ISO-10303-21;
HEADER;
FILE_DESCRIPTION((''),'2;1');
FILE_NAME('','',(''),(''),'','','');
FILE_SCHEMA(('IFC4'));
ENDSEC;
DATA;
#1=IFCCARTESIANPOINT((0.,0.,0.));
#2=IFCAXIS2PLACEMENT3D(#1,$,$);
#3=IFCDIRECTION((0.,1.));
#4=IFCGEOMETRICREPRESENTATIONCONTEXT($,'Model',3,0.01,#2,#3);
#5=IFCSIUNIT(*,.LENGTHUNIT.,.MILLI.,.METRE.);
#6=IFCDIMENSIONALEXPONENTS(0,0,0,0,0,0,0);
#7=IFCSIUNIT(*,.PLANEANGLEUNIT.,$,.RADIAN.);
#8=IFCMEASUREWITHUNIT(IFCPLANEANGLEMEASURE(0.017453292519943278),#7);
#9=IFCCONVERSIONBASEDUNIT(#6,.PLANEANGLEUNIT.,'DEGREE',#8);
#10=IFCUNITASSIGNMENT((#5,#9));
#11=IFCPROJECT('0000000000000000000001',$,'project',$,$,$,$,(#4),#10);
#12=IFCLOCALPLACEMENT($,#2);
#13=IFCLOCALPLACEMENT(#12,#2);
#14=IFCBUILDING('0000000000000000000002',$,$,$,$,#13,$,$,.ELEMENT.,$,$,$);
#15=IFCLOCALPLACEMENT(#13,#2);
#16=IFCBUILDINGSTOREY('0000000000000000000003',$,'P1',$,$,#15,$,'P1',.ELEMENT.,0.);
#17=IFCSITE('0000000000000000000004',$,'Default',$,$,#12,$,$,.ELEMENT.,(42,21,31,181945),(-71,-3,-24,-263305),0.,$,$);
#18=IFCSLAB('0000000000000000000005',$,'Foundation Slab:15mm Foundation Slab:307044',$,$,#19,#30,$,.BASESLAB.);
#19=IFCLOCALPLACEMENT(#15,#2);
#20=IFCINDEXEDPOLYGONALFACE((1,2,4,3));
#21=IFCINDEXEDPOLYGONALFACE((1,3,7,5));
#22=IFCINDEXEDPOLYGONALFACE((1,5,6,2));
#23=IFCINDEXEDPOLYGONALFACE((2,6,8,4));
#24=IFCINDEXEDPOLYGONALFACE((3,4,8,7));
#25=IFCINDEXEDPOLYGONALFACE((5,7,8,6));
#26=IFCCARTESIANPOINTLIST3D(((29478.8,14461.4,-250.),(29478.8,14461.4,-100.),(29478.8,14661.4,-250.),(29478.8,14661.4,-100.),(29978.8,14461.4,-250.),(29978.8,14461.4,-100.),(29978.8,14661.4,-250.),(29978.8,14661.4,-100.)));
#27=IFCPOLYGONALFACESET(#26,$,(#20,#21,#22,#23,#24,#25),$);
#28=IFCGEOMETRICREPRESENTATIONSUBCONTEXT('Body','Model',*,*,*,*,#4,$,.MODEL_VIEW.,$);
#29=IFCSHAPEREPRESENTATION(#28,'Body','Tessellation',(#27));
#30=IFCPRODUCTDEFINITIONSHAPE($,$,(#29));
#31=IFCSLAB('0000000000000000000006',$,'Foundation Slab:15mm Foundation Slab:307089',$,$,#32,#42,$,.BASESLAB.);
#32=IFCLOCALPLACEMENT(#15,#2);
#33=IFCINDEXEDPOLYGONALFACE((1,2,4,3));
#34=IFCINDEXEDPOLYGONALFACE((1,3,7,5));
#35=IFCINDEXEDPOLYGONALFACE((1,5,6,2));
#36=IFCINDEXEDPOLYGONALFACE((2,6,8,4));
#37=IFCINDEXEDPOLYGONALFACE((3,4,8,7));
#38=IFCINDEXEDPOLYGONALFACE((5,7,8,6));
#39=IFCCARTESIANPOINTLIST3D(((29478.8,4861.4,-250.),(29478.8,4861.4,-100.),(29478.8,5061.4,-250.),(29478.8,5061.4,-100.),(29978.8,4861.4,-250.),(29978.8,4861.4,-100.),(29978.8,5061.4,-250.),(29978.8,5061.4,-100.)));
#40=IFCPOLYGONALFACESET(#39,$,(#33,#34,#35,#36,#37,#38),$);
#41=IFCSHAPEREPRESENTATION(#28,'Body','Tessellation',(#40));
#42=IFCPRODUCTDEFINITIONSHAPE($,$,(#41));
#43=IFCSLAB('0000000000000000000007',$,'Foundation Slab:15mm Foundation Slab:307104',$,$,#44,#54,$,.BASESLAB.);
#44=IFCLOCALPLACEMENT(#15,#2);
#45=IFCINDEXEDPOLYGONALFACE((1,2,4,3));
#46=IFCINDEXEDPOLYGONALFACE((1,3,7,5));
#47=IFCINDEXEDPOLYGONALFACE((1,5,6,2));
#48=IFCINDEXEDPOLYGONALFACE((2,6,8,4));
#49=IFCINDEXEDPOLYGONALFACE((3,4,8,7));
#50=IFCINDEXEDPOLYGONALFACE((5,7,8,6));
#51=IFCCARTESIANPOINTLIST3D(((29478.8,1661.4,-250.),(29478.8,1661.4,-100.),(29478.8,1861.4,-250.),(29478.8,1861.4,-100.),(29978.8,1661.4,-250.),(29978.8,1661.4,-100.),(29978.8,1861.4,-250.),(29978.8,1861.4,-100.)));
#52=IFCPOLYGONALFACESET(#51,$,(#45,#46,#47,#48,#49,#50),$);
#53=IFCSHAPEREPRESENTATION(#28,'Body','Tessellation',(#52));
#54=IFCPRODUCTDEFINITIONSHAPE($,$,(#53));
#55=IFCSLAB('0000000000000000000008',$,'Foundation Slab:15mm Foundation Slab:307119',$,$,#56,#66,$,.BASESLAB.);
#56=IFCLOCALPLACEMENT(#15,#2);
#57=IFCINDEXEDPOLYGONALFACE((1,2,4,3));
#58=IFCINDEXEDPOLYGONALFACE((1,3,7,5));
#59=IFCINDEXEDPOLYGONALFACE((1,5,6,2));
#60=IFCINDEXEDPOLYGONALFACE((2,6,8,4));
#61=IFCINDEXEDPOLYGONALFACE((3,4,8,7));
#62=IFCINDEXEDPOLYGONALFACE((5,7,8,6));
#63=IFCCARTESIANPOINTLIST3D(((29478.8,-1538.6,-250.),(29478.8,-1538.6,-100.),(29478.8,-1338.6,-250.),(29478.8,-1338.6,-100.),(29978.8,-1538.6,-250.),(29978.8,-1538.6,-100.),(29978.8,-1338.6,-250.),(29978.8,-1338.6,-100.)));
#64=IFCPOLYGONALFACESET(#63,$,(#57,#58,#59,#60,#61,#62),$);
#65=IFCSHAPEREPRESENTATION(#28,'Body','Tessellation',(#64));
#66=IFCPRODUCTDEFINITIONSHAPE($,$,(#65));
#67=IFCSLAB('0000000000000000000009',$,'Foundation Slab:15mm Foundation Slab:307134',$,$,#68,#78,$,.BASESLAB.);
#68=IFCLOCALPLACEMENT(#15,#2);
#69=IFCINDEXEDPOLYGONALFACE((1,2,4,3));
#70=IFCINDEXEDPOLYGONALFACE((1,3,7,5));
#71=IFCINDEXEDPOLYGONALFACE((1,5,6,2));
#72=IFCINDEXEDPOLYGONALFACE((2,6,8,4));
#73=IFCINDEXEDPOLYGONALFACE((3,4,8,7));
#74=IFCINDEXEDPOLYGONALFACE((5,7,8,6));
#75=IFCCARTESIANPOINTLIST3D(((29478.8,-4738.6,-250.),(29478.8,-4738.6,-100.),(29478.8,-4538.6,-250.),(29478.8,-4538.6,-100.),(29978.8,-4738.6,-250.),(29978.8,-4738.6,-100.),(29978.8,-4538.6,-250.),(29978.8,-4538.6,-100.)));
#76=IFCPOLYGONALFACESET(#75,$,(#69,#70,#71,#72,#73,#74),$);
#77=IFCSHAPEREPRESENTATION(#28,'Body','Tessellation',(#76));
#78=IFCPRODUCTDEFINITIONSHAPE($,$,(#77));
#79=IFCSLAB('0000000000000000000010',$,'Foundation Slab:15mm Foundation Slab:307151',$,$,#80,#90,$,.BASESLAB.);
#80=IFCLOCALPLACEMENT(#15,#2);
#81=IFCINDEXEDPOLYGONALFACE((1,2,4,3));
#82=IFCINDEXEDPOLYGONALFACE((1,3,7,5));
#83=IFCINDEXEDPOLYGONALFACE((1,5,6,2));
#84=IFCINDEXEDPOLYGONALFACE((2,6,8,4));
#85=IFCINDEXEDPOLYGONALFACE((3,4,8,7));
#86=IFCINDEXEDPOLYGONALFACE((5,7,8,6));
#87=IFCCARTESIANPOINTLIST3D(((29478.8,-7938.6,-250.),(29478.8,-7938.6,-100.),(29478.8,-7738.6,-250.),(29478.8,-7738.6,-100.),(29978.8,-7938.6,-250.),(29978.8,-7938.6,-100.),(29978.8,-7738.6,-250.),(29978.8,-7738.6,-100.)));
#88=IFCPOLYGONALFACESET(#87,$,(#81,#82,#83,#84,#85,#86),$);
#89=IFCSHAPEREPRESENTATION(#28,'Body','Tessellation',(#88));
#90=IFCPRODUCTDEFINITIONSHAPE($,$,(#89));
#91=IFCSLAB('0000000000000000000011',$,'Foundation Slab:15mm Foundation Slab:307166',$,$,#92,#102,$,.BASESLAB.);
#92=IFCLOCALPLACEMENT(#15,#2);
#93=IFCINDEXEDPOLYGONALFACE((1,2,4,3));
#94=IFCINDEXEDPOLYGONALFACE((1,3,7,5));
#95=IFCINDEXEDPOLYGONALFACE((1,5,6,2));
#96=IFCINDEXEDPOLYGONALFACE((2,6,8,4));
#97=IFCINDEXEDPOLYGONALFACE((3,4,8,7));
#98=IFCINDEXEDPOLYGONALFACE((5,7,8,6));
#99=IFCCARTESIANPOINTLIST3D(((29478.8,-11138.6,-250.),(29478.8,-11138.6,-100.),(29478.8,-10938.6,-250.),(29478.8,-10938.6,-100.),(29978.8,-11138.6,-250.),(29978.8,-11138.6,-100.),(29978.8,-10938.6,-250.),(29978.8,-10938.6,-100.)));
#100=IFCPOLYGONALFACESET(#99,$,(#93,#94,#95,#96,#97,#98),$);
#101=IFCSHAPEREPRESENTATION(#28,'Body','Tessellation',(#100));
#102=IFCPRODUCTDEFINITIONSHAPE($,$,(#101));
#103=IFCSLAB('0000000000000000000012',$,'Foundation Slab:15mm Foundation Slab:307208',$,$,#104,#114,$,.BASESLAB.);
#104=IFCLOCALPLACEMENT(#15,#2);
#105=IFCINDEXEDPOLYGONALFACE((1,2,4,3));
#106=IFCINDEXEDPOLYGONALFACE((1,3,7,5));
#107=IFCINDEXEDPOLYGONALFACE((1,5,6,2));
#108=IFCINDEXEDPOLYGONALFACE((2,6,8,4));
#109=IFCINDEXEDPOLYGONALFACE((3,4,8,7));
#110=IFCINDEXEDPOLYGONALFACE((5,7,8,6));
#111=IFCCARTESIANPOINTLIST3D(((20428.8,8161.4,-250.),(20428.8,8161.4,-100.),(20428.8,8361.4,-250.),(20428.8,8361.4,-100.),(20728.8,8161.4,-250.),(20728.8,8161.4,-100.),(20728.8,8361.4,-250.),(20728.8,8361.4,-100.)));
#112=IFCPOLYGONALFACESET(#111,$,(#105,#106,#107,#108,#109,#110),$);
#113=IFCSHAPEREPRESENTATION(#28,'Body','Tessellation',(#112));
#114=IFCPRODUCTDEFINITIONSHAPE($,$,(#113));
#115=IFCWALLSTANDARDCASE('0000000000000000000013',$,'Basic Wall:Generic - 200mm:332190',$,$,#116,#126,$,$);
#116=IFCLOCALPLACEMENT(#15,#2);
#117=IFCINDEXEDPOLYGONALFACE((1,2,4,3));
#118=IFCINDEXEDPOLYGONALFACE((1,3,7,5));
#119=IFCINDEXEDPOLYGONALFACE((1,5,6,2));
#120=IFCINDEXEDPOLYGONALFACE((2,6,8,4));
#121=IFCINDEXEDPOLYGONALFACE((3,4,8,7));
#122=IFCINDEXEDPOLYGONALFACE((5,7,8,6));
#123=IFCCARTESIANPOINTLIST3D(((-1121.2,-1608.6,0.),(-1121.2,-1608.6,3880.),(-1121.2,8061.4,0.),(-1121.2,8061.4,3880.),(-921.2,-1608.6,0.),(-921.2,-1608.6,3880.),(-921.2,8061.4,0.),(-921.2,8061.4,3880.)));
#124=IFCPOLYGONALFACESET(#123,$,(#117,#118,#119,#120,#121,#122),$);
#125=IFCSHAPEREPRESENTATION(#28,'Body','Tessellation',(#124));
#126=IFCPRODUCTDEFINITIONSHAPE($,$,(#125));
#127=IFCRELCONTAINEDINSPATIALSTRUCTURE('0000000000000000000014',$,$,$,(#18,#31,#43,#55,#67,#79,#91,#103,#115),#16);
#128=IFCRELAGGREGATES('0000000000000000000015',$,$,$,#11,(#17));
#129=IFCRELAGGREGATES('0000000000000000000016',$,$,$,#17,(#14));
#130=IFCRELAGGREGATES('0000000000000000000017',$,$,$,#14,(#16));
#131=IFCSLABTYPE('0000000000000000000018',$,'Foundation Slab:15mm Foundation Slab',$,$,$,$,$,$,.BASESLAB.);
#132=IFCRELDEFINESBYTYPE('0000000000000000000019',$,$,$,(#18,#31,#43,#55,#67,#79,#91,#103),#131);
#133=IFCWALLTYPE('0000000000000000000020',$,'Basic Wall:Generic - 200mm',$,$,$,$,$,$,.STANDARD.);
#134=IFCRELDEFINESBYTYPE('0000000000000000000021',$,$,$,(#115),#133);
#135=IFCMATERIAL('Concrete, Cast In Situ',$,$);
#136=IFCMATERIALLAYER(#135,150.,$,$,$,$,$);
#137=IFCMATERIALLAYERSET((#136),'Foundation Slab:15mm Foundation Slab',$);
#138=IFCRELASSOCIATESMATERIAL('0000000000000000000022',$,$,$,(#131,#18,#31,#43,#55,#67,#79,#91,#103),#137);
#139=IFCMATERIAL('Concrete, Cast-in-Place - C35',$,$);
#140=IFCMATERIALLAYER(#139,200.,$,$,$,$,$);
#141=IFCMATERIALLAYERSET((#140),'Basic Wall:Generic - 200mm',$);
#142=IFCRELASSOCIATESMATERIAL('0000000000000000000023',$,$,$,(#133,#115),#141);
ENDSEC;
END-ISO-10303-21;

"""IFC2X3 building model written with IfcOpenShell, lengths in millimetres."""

from ifc_helpers import new_model, entity, si_unit, converted_unit, direction, frame, frame_2d, origin, origin_2d_with_axis, place, context, subcontext, project, spatial, rectangle, extrude, material, layer, layer_set, layer_usage, type_object, element, save


model = new_model("IFC2X3")

# Units and contexts
model_context = context("Model", 3, precision=0.01, world=origin(), true_north=direction((0.0, 1.0)))
body_context = subcontext(model_context, "Body", "Model", "MODEL_VIEW")
ifc_project = project(units=[si_unit("LENGTHUNIT", "METRE", prefix="MILLI"), converted_unit("PLANEANGLEUNIT", "DEGREE", entity("IfcPlaneAngleMeasure", 0.017453292519943278), si_unit("PLANEANGLEUNIT", "RADIAN"), dimensions=[0, 0, 0, 0, 0, 0, 0])], contexts=[model_context])

# Site, building, storey
site_placement = place(None, origin())
site = spatial("IfcSite", under=ifc_project, at=site_placement, Name="Default", CompositionType="ELEMENT", RefLatitude=(42, 21, 31, 181945), RefLongitude=(-71, -3, -24, -263305), RefElevation=0.0)
building_placement = place(site_placement, origin())
building = spatial("IfcBuilding", under=site, at=building_placement, CompositionType="ELEMENT")
storey_placement = place(building_placement, origin())
storey = spatial("IfcBuildingStorey", under=building, at=storey_placement, Name="P1", LongName="P1", CompositionType="ELEMENT", Elevation=0.0)

# Shared definitions
ifc_material_1 = material(Name="Concrete, Cast-in-Place - C35")

# Slabs
ifc_material_2 = material(Name="Concrete, Cast In Situ")
ifc_layer_1 = layer(ifc_material_2, 150.0)
ifc_layer_set_1 = layer_set([ifc_layer_1], Name="Foundation Slab:15mm Foundation Slab")
slab_type = type_object("IfcSlabType", Name="Foundation Slab:15mm Foundation Slab", PredefinedType="BASESLAB", material=ifc_layer_set_1)
ifc_layer_usage_1 = layer_usage(ifc_layer_set_1, "AXIS3", "POSITIVE", 0.0)
slab_1_placement = place(storey_placement, origin())
element("IfcSlab", 1, at=slab_1_placement, inside=storey, type_object=slab_type, material=ifc_layer_usage_1, Name="Foundation Slab:15mm Foundation Slab:307044", PredefinedType="BASESLAB", context=body_context, shape_type="SweptSolid", body=[
    extrude(rectangle(XDim=200.0, YDim=500.0, at=frame_2d((0.0, 0.0), x_axis=(1.0, 0.0))), frame((29728.8, 14561.4, -100.0), z_axis=(0.0, 0.0, -1.0), x_axis=(0.0, 1.0, 0.0)), (0.0, 0.0, 1.0), 150.0),
])
ifc_layer_usage_2 = layer_usage(ifc_layer_set_1, "AXIS3", "POSITIVE", 0.0)
slab_2_placement = place(storey_placement, origin())
element("IfcSlab", 2, at=slab_2_placement, inside=storey, type_object=slab_type, material=ifc_layer_usage_2, Name="Foundation Slab:15mm Foundation Slab:307089", PredefinedType="BASESLAB", context=body_context, shape_type="SweptSolid", body=[
    extrude(rectangle(XDim=200.0, YDim=500.0, at=origin_2d_with_axis()), frame((29728.8, 4961.4, -100.0), z_axis=(0.0, 0.0, -1.0), x_axis=(0.0, 1.0, 0.0)), (0.0, 0.0, 1.0), 150.0),
])
ifc_layer_usage_3 = layer_usage(ifc_layer_set_1, "AXIS3", "POSITIVE", 0.0)
slab_3_placement = place(storey_placement, origin())
element("IfcSlab", 3, at=slab_3_placement, inside=storey, type_object=slab_type, material=ifc_layer_usage_3, Name="Foundation Slab:15mm Foundation Slab:307104", PredefinedType="BASESLAB", context=body_context, shape_type="SweptSolid", body=[
    extrude(rectangle(XDim=200.0, YDim=500.0, at=origin_2d_with_axis()), frame((29728.8, 1761.4, -100.0), z_axis=(0.0, 0.0, -1.0), x_axis=(0.0, 1.0, 0.0)), (0.0, 0.0, 1.0), 150.0),
])
ifc_layer_usage_4 = layer_usage(ifc_layer_set_1, "AXIS3", "POSITIVE", 0.0)
slab_4_placement = place(storey_placement, origin())
element("IfcSlab", 4, at=slab_4_placement, inside=storey, type_object=slab_type, material=ifc_layer_usage_4, Name="Foundation Slab:15mm Foundation Slab:307119", PredefinedType="BASESLAB", context=body_context, shape_type="SweptSolid", body=[
    extrude(rectangle(XDim=200.0, YDim=500.0, at=origin_2d_with_axis()), frame((29728.8, -1438.6, -100.0), z_axis=(0.0, 0.0, -1.0), x_axis=(0.0, 1.0, 0.0)), (0.0, 0.0, 1.0), 150.0),
])
ifc_layer_usage_5 = layer_usage(ifc_layer_set_1, "AXIS3", "POSITIVE", 0.0)
slab_5_placement = place(storey_placement, origin())
element("IfcSlab", 5, at=slab_5_placement, inside=storey, type_object=slab_type, material=ifc_layer_usage_5, Name="Foundation Slab:15mm Foundation Slab:307134", PredefinedType="BASESLAB", context=body_context, shape_type="SweptSolid", body=[
    extrude(rectangle(XDim=200.0, YDim=500.0, at=origin_2d_with_axis()), frame((29728.8, -4638.6, -100.0), z_axis=(0.0, 0.0, -1.0), x_axis=(0.0, 1.0, 0.0)), (0.0, 0.0, 1.0), 150.0),
])
ifc_layer_usage_6 = layer_usage(ifc_layer_set_1, "AXIS3", "POSITIVE", 0.0)
slab_6_placement = place(storey_placement, origin())
element("IfcSlab", 6, at=slab_6_placement, inside=storey, type_object=slab_type, material=ifc_layer_usage_6, Name="Foundation Slab:15mm Foundation Slab:307151", PredefinedType="BASESLAB", context=body_context, shape_type="SweptSolid", body=[
    extrude(rectangle(XDim=200.0, YDim=500.0, at=origin_2d_with_axis()), frame((29728.8, -7838.6, -100.0), z_axis=(0.0, 0.0, -1.0), x_axis=(0.0, 1.0, 0.0)), (0.0, 0.0, 1.0), 150.0),
])
ifc_layer_usage_7 = layer_usage(ifc_layer_set_1, "AXIS3", "POSITIVE", 0.0)
slab_7_placement = place(storey_placement, origin())
element("IfcSlab", 7, at=slab_7_placement, inside=storey, type_object=slab_type, material=ifc_layer_usage_7, Name="Foundation Slab:15mm Foundation Slab:307166", PredefinedType="BASESLAB", context=body_context, shape_type="SweptSolid", body=[
    extrude(rectangle(XDim=200.0, YDim=500.0, at=frame_2d((0.0, 0.0), x_axis=(1.0, 0.0))), frame((29728.8, -11038.6, -100.0), z_axis=(0.0, 0.0, -1.0), x_axis=(0.0, 1.0, 0.0)), (0.0, 0.0, 1.0), 150.0),
])
ifc_layer_usage_8 = layer_usage(ifc_layer_set_1, "AXIS3", "POSITIVE", 0.0)
slab_8_placement = place(storey_placement, origin())
element("IfcSlab", 8, at=slab_8_placement, inside=storey, type_object=slab_type, material=ifc_layer_usage_8, Name="Foundation Slab:15mm Foundation Slab:307208", PredefinedType="BASESLAB", context=body_context, shape_type="SweptSolid", body=[
    extrude(rectangle(XDim=200.0, YDim=300.0, at=origin_2d_with_axis()), frame((20578.8, 8261.4, -100.0), z_axis=(0.0, 0.0, -1.0), x_axis=(0.0, 1.0, 0.0)), (0.0, 0.0, 1.0), 150.0),
])

# Wall
ifc_layer_2 = layer(ifc_material_1, 200.0)
ifc_layer_set_2 = layer_set([ifc_layer_2], Name="Basic Wall:Generic - 200mm")
ifc_layer_usage_9 = layer_usage(ifc_layer_set_2, "AXIS2", "NEGATIVE", 100.0)
wall_type = type_object("IfcWallType", Name="Basic Wall:Generic - 200mm", PredefinedType="STANDARD", material=ifc_layer_set_2)
wall_placement = place(storey_placement, frame((-1021.2, 8061.4, 0.0), z_axis=(0.0, 0.0, 1.0), x_axis=(0.0, -1.0, 0.0)))
element("IfcWallStandardCase", 9, at=wall_placement, inside=storey, type_object=wall_type, material=ifc_layer_usage_9, Name="Basic Wall:Generic - 200mm:332190", context=body_context, shape_type="SweptSolid", body=[
    extrude(rectangle(XDim=9670.0, YDim=200.0, at=frame_2d((4835.0, 0.0), x_axis=(-1.0, 0.0))), origin(), (0.0, 0.0, 1.0), 3880.0),
])

save(model, "model.ifc")
